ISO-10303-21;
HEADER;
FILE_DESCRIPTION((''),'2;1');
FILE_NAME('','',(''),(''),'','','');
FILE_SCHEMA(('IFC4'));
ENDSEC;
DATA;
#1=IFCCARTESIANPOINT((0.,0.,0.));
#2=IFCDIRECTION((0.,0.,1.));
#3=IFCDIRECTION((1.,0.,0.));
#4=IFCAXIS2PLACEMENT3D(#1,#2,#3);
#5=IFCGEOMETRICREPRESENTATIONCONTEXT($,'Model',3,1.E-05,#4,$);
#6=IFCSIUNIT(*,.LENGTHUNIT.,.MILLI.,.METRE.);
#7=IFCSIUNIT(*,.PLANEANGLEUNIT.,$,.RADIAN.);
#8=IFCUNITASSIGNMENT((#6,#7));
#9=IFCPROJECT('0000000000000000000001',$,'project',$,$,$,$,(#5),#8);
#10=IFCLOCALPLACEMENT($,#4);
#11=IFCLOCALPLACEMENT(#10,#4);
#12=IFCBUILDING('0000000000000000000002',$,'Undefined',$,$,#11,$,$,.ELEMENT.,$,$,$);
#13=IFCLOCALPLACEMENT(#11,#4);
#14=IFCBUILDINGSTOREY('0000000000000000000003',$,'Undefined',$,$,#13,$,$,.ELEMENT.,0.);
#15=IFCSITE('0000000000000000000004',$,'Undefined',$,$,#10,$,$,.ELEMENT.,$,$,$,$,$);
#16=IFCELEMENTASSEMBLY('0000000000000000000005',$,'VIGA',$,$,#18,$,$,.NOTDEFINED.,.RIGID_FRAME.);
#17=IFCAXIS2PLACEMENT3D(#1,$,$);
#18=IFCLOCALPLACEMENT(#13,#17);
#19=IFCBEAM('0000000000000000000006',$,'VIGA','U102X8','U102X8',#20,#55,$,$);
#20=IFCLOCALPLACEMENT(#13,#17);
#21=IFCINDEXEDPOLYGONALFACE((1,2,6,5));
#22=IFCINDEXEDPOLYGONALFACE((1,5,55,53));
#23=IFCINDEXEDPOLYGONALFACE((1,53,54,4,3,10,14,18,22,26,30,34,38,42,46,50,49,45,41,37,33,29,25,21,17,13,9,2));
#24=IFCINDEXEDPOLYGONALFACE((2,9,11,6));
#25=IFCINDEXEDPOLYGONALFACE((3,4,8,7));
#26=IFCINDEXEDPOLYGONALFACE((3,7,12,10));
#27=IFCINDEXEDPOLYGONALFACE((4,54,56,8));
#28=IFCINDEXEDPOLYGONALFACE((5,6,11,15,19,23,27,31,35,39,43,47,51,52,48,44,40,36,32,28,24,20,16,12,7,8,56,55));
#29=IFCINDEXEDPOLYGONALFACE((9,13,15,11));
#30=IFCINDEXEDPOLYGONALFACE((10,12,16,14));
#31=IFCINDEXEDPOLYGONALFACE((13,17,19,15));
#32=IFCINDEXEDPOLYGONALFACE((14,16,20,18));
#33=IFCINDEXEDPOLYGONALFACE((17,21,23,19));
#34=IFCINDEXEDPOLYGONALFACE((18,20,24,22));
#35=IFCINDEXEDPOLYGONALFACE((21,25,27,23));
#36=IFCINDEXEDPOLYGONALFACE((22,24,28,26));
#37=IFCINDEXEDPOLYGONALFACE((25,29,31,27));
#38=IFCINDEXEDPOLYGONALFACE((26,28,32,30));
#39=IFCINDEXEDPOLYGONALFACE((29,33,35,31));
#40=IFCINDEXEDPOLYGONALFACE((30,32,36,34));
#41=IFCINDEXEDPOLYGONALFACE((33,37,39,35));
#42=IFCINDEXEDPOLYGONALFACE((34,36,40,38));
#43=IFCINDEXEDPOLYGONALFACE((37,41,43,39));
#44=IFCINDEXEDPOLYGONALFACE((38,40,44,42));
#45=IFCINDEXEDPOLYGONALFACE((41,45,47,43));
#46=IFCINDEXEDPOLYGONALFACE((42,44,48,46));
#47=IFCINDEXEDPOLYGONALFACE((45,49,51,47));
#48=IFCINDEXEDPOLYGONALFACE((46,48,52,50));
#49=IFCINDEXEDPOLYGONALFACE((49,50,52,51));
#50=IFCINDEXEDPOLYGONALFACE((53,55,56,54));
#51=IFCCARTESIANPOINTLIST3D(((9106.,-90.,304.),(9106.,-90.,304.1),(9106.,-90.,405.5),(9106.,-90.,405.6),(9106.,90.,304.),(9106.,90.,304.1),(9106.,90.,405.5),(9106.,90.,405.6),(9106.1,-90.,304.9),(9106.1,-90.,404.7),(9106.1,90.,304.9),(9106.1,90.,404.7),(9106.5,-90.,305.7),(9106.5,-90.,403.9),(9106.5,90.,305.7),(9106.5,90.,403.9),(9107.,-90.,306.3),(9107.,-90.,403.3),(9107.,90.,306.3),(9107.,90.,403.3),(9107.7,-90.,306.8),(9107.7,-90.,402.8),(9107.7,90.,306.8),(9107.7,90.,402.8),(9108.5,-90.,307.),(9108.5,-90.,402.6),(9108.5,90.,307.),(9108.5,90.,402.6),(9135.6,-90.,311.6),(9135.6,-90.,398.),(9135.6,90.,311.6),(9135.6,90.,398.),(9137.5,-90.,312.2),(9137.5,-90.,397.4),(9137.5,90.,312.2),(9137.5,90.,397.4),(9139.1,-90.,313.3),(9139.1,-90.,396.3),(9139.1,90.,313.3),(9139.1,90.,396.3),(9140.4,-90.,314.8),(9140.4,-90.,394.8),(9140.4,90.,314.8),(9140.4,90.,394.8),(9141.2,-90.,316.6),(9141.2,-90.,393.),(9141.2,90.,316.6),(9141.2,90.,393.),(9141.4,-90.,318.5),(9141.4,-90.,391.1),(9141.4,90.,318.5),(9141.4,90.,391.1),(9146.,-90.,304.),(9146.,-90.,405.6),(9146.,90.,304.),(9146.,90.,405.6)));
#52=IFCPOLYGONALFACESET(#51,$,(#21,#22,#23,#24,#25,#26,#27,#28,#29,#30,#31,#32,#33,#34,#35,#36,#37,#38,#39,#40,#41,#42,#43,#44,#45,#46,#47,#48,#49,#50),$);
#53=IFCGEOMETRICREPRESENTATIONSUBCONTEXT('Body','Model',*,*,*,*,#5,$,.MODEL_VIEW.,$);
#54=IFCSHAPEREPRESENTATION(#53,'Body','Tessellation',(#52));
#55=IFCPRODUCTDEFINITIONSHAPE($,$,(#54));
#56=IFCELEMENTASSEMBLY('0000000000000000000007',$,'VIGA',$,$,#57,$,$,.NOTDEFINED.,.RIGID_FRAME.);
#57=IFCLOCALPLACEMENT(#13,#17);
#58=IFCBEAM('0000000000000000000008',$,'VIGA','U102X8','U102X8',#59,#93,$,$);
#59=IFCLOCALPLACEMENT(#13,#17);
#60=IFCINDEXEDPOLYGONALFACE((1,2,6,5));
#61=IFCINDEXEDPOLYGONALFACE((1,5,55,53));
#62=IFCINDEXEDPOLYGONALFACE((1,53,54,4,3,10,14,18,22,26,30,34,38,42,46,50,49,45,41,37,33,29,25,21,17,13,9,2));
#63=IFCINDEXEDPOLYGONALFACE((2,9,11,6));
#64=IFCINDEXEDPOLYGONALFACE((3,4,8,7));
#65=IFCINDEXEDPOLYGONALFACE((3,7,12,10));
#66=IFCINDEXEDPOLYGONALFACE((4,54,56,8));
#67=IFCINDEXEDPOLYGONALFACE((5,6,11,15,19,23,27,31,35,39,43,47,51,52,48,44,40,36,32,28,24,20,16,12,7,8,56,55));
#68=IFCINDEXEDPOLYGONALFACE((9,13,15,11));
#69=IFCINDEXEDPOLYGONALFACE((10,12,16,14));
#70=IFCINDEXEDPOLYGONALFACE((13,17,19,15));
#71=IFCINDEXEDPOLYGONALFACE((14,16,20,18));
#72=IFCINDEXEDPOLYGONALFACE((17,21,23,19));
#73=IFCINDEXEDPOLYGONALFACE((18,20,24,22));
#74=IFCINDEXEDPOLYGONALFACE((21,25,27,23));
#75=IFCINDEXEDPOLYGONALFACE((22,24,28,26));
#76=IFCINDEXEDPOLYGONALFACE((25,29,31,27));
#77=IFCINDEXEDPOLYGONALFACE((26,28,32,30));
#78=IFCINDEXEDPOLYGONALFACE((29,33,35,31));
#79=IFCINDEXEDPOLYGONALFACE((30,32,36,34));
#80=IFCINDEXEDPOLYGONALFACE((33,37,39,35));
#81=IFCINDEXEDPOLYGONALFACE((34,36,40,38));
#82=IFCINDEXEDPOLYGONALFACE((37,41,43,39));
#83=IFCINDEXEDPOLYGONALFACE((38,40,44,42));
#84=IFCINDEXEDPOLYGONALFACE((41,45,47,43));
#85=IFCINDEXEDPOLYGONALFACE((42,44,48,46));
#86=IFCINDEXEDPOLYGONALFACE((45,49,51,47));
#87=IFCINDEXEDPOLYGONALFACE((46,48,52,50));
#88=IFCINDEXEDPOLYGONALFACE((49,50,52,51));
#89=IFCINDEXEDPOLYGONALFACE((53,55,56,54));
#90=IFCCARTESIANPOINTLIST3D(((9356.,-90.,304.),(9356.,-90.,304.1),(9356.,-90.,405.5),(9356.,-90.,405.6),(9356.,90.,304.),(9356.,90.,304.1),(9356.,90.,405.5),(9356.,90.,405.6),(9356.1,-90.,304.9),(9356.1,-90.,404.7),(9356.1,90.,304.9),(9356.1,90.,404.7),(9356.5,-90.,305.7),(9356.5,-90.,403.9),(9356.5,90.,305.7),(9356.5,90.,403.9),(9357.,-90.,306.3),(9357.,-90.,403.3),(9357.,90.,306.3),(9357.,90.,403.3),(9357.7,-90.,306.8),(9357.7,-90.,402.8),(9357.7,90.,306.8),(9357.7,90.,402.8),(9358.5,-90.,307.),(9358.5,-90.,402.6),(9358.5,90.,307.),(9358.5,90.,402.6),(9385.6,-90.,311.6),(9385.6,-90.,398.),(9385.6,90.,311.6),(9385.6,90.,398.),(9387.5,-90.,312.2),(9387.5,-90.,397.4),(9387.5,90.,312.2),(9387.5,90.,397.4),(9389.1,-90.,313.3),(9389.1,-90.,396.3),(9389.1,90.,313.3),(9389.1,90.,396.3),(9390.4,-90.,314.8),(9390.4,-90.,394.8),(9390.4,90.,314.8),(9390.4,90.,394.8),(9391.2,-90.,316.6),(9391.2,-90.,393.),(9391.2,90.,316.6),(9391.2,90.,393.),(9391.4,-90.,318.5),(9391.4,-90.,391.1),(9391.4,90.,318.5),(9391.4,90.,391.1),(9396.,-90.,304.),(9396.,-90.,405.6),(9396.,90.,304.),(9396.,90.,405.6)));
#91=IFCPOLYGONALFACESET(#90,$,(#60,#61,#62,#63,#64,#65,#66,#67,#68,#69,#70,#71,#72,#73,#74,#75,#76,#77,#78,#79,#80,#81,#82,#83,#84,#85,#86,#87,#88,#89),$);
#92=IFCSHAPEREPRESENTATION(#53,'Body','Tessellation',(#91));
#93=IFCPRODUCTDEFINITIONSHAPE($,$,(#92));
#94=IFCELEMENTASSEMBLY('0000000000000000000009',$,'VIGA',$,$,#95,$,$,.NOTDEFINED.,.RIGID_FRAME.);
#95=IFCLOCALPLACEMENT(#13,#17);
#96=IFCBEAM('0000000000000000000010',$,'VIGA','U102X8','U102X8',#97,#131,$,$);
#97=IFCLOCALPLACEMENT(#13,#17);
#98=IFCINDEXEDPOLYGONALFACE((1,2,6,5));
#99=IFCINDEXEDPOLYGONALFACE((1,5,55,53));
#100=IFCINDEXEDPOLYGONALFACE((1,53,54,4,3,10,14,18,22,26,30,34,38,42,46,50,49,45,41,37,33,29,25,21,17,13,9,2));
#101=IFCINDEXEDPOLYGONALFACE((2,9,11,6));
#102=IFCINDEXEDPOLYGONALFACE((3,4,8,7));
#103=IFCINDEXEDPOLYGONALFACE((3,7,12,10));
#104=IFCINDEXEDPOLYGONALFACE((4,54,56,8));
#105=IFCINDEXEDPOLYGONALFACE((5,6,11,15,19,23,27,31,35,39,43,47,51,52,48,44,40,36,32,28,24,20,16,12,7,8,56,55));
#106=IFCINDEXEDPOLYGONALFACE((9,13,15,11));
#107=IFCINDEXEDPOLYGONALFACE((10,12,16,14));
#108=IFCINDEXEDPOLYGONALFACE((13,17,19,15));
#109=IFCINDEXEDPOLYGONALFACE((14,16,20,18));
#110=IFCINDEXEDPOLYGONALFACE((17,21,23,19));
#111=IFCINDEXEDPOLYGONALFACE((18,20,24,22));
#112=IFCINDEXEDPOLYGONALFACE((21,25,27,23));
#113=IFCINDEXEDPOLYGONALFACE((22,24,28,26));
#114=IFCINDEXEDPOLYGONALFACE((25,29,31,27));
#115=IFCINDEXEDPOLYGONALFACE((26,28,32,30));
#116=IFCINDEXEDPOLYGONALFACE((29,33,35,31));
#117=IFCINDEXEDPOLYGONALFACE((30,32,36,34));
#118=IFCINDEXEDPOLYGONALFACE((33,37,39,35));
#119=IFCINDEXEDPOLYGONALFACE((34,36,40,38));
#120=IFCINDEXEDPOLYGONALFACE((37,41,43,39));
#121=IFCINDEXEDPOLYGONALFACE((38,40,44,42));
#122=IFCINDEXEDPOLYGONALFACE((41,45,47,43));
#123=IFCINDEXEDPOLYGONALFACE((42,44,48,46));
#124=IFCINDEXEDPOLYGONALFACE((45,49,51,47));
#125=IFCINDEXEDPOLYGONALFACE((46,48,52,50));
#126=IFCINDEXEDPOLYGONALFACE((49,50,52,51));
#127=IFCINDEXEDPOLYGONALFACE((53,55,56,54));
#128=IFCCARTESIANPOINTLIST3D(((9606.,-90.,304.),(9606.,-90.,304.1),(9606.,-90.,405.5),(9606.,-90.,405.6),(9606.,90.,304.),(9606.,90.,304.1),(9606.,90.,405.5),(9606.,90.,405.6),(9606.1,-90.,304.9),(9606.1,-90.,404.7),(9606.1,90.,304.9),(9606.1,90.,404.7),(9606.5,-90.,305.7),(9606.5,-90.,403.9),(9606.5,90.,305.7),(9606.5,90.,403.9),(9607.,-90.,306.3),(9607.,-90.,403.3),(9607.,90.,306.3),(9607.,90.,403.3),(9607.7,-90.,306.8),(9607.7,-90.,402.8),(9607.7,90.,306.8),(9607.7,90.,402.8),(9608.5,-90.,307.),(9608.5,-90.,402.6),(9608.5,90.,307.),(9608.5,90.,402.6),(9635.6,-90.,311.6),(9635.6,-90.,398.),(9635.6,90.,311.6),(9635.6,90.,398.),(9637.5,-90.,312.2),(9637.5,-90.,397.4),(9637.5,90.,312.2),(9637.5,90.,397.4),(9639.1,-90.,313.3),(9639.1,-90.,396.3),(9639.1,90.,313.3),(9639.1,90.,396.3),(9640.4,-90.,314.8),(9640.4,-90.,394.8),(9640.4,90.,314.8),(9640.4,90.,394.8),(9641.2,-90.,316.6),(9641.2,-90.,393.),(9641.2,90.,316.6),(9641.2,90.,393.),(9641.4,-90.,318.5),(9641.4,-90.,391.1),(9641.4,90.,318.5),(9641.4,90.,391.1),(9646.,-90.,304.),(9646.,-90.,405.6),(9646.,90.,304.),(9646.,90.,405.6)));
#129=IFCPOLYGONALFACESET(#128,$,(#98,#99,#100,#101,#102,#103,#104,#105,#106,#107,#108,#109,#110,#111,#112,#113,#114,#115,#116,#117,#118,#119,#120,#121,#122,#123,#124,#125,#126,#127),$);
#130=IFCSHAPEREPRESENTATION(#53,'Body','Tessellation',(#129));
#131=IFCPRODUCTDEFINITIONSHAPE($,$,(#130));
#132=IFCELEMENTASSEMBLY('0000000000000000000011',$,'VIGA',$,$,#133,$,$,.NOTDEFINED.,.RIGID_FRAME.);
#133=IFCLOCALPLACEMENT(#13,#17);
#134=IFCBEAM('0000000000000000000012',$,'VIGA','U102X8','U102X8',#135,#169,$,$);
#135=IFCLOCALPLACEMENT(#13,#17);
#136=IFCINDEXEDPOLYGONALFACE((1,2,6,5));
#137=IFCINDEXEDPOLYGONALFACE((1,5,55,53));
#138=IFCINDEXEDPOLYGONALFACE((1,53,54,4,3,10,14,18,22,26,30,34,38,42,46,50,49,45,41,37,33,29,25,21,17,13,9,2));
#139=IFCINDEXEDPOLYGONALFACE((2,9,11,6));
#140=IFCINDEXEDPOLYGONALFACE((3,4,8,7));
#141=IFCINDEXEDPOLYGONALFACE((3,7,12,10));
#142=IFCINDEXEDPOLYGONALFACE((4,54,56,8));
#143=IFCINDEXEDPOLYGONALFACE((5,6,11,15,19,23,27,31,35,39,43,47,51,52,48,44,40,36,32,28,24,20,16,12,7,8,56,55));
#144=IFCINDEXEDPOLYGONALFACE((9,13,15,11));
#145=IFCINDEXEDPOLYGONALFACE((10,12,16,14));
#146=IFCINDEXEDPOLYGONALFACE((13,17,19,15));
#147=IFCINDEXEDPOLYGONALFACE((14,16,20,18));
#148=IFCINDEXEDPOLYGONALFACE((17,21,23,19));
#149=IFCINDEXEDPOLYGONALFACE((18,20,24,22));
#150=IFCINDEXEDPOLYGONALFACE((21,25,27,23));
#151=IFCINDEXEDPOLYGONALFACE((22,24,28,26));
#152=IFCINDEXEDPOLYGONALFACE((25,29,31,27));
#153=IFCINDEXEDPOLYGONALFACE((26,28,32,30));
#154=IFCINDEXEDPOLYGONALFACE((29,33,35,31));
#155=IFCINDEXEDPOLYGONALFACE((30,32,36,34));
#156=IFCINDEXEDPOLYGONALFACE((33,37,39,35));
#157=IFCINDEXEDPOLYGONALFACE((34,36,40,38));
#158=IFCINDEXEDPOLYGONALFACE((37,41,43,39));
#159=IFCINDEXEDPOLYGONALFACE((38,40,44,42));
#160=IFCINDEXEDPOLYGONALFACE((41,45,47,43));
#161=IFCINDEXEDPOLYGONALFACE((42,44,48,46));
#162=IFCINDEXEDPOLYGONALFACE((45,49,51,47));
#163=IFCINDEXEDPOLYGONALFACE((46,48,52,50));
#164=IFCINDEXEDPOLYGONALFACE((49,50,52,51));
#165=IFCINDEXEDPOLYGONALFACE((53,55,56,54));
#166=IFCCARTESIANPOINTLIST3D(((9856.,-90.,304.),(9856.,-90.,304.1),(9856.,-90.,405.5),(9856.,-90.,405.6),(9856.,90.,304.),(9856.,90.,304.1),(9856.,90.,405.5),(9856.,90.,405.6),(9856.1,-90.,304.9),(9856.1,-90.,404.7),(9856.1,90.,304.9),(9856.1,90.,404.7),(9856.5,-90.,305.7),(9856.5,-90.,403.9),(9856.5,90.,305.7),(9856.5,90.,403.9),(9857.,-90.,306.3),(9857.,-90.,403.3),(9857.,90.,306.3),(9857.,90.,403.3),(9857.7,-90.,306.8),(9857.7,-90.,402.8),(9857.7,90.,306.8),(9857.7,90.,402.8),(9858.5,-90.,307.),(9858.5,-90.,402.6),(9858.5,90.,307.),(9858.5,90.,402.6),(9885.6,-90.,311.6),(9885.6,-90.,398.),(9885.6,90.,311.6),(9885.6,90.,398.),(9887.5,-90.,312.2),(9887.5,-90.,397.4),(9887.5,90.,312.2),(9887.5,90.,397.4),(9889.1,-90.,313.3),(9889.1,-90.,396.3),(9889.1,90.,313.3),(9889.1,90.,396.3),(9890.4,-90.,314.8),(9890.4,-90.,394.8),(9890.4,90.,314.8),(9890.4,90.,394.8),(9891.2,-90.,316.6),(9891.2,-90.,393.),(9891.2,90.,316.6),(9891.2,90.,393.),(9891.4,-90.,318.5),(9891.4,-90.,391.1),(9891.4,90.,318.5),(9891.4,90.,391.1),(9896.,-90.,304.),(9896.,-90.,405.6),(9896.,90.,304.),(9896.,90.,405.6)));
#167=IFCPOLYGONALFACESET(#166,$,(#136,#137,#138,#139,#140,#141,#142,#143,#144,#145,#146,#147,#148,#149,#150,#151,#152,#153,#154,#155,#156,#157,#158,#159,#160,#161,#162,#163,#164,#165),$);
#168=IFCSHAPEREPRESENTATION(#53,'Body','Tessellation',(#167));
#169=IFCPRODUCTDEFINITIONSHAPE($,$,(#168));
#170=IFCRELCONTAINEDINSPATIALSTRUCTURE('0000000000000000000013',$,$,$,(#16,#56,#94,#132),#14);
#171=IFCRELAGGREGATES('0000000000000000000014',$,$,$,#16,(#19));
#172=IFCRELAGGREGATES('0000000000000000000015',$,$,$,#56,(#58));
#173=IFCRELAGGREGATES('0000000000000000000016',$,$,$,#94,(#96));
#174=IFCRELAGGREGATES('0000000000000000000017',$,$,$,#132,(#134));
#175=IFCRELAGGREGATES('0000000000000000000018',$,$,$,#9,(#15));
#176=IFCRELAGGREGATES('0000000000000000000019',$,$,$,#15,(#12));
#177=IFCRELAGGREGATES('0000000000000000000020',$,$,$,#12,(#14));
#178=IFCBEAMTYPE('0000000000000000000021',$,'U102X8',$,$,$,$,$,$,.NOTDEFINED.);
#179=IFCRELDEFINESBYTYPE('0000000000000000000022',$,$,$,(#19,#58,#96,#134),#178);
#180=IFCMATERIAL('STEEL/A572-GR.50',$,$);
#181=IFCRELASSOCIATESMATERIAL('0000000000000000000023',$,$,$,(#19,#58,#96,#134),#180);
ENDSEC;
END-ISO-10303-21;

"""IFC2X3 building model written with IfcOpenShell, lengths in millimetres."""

from ifc_helpers import new_model, si_unit, frame, origin_with_axes, origin_2d_with_axis, place, context, subcontext, project, spatial, u_section, extrude, material, type_object, element, aggregate, save


model = new_model("IFC2X3")

# Units and contexts
model_context = context("Model", 3, precision=1e-05, world=origin_with_axes())
body_context = subcontext(model_context, "Body", "Model", "MODEL_VIEW")
ifc_project = project(units=[si_unit("LENGTHUNIT", "METRE", prefix="MILLI"), si_unit("PLANEANGLEUNIT", "RADIAN")], contexts=[model_context])

# Site, building, storey
site_placement = place(None, origin_with_axes())
site = spatial("IfcSite", under=ifc_project, at=site_placement, Name="Undefined", CompositionType="ELEMENT")
building_placement = place(site_placement, origin_with_axes())
building = spatial("IfcBuilding", under=site, at=building_placement, Name="Undefined", CompositionType="ELEMENT")
storey_placement = place(building_placement, origin_with_axes())
storey = spatial("IfcBuildingStorey", under=building, at=storey_placement, Name="Undefined", CompositionType="ELEMENT", Elevation=0.0)

# Element assemblies, beams
ifc_material_1 = material(Name="STEEL/A572-GR.50")
beam_type_1 = type_object("IfcBeamType", Name="U102X8", PredefinedType="NOTDEFINED")
assembly_1_placement = place(storey_placement, origin_with_axes())
assembly_1 = element("IfcElementAssembly", 1, at=assembly_1_placement, inside=storey, Name="VIGA", AssemblyPlace="NOTDEFINED", PredefinedType="RIGID_FRAME")
beam_1_placement = place(assembly_1_placement, frame((9126.0, 90.0, 354.8), z_axis=(0.0, 0.0, 1.0), x_axis=(0.0, -1.0, 0.0)))
beam_1 = element("IfcBeam", 2, at=beam_1_placement, type_object=beam_type_1, material=ifc_material_1, Name="VIGA", Description="U102X8", ObjectType="U102X8", context=body_context, shape_type="SweptSolid", body=[
    extrude(u_section(Depth=101.6, FlangeWidth=40.0, WebThickness=4.6, FlangeThickness=6.0, FilletRadius=7.0, EdgeRadius=3.0, FlangeSlope=0.16839, at=origin_2d_with_axis()), frame((180.0, 0.0, 0.0), z_axis=(-1.0, 0.0, 0.0), x_axis=(0.0, -1.0, 0.0)), (0.0, 0.0, 1.0), 180.0),
])
aggregate(assembly_1, [beam_1])
assembly_2_placement = place(storey_placement, origin_with_axes())
assembly_2 = element("IfcElementAssembly", 3, at=assembly_2_placement, inside=storey, Name="VIGA", AssemblyPlace="NOTDEFINED", PredefinedType="RIGID_FRAME")
beam_2_placement = place(assembly_2_placement, frame((9376.0, 90.0, 354.8), z_axis=(0.0, 0.0, 1.0), x_axis=(0.0, -1.0, 0.0)))
beam_2 = element("IfcBeam", 4, at=beam_2_placement, type_object=beam_type_1, material=ifc_material_1, Name="VIGA", Description="U102X8", ObjectType="U102X8", context=body_context, shape_type="SweptSolid", body=[
    extrude(u_section(Depth=101.6, FlangeWidth=40.0, WebThickness=4.6, FlangeThickness=6.0, FilletRadius=7.0, EdgeRadius=3.0, FlangeSlope=0.16839, at=origin_2d_with_axis()), frame((180.0, 0.0, 0.0), z_axis=(-1.0, 0.0, 0.0), x_axis=(0.0, -1.0, 0.0)), (0.0, 0.0, 1.0), 180.0),
])
aggregate(assembly_2, [beam_2])
assembly_3_placement = place(storey_placement, origin_with_axes())
assembly_3 = element("IfcElementAssembly", 5, at=assembly_3_placement, inside=storey, Name="VIGA", AssemblyPlace="NOTDEFINED", PredefinedType="RIGID_FRAME")
beam_3_placement = place(assembly_3_placement, frame((9626.0, 90.0, 354.8), z_axis=(0.0, 0.0, 1.0), x_axis=(0.0, -1.0, 0.0)))
beam_3 = element("IfcBeam", 6, at=beam_3_placement, type_object=beam_type_1, material=ifc_material_1, Name="VIGA", Description="U102X8", ObjectType="U102X8", context=body_context, shape_type="SweptSolid", body=[
    extrude(u_section(Depth=101.6, FlangeWidth=40.0, WebThickness=4.6, FlangeThickness=6.0, FilletRadius=7.0, EdgeRadius=3.0, FlangeSlope=0.16839, at=origin_2d_with_axis()), frame((180.0, 0.0, 0.0), z_axis=(-1.0, 0.0, 0.0), x_axis=(0.0, -1.0, 0.0)), (0.0, 0.0, 1.0), 180.0),
])
aggregate(assembly_3, [beam_3])
assembly_4_placement = place(storey_placement, origin_with_axes())
assembly_4 = element("IfcElementAssembly", 7, at=assembly_4_placement, inside=storey, Name="VIGA", AssemblyPlace="NOTDEFINED", PredefinedType="RIGID_FRAME")
beam_4_placement = place(assembly_4_placement, frame((9876.0, 90.0, 354.8), z_axis=(0.0, 0.0, 1.0), x_axis=(0.0, -1.0, 0.0)))
beam_4 = element("IfcBeam", 8, at=beam_4_placement, type_object=beam_type_1, material=ifc_material_1, Name="VIGA", Description="U102X8", ObjectType="U102X8", context=body_context, shape_type="SweptSolid", body=[
    extrude(u_section(Depth=101.6, FlangeWidth=40.0, WebThickness=4.6, FlangeThickness=6.0, FilletRadius=7.0, EdgeRadius=3.0, FlangeSlope=0.16839, at=origin_2d_with_axis()), frame((180.0, 0.0, 0.0), z_axis=(-1.0, 0.0, 0.0), x_axis=(0.0, -1.0, 0.0)), (0.0, 0.0, 1.0), 180.0),
])
aggregate(assembly_4, [beam_4])

save(model, "model.ifc")
